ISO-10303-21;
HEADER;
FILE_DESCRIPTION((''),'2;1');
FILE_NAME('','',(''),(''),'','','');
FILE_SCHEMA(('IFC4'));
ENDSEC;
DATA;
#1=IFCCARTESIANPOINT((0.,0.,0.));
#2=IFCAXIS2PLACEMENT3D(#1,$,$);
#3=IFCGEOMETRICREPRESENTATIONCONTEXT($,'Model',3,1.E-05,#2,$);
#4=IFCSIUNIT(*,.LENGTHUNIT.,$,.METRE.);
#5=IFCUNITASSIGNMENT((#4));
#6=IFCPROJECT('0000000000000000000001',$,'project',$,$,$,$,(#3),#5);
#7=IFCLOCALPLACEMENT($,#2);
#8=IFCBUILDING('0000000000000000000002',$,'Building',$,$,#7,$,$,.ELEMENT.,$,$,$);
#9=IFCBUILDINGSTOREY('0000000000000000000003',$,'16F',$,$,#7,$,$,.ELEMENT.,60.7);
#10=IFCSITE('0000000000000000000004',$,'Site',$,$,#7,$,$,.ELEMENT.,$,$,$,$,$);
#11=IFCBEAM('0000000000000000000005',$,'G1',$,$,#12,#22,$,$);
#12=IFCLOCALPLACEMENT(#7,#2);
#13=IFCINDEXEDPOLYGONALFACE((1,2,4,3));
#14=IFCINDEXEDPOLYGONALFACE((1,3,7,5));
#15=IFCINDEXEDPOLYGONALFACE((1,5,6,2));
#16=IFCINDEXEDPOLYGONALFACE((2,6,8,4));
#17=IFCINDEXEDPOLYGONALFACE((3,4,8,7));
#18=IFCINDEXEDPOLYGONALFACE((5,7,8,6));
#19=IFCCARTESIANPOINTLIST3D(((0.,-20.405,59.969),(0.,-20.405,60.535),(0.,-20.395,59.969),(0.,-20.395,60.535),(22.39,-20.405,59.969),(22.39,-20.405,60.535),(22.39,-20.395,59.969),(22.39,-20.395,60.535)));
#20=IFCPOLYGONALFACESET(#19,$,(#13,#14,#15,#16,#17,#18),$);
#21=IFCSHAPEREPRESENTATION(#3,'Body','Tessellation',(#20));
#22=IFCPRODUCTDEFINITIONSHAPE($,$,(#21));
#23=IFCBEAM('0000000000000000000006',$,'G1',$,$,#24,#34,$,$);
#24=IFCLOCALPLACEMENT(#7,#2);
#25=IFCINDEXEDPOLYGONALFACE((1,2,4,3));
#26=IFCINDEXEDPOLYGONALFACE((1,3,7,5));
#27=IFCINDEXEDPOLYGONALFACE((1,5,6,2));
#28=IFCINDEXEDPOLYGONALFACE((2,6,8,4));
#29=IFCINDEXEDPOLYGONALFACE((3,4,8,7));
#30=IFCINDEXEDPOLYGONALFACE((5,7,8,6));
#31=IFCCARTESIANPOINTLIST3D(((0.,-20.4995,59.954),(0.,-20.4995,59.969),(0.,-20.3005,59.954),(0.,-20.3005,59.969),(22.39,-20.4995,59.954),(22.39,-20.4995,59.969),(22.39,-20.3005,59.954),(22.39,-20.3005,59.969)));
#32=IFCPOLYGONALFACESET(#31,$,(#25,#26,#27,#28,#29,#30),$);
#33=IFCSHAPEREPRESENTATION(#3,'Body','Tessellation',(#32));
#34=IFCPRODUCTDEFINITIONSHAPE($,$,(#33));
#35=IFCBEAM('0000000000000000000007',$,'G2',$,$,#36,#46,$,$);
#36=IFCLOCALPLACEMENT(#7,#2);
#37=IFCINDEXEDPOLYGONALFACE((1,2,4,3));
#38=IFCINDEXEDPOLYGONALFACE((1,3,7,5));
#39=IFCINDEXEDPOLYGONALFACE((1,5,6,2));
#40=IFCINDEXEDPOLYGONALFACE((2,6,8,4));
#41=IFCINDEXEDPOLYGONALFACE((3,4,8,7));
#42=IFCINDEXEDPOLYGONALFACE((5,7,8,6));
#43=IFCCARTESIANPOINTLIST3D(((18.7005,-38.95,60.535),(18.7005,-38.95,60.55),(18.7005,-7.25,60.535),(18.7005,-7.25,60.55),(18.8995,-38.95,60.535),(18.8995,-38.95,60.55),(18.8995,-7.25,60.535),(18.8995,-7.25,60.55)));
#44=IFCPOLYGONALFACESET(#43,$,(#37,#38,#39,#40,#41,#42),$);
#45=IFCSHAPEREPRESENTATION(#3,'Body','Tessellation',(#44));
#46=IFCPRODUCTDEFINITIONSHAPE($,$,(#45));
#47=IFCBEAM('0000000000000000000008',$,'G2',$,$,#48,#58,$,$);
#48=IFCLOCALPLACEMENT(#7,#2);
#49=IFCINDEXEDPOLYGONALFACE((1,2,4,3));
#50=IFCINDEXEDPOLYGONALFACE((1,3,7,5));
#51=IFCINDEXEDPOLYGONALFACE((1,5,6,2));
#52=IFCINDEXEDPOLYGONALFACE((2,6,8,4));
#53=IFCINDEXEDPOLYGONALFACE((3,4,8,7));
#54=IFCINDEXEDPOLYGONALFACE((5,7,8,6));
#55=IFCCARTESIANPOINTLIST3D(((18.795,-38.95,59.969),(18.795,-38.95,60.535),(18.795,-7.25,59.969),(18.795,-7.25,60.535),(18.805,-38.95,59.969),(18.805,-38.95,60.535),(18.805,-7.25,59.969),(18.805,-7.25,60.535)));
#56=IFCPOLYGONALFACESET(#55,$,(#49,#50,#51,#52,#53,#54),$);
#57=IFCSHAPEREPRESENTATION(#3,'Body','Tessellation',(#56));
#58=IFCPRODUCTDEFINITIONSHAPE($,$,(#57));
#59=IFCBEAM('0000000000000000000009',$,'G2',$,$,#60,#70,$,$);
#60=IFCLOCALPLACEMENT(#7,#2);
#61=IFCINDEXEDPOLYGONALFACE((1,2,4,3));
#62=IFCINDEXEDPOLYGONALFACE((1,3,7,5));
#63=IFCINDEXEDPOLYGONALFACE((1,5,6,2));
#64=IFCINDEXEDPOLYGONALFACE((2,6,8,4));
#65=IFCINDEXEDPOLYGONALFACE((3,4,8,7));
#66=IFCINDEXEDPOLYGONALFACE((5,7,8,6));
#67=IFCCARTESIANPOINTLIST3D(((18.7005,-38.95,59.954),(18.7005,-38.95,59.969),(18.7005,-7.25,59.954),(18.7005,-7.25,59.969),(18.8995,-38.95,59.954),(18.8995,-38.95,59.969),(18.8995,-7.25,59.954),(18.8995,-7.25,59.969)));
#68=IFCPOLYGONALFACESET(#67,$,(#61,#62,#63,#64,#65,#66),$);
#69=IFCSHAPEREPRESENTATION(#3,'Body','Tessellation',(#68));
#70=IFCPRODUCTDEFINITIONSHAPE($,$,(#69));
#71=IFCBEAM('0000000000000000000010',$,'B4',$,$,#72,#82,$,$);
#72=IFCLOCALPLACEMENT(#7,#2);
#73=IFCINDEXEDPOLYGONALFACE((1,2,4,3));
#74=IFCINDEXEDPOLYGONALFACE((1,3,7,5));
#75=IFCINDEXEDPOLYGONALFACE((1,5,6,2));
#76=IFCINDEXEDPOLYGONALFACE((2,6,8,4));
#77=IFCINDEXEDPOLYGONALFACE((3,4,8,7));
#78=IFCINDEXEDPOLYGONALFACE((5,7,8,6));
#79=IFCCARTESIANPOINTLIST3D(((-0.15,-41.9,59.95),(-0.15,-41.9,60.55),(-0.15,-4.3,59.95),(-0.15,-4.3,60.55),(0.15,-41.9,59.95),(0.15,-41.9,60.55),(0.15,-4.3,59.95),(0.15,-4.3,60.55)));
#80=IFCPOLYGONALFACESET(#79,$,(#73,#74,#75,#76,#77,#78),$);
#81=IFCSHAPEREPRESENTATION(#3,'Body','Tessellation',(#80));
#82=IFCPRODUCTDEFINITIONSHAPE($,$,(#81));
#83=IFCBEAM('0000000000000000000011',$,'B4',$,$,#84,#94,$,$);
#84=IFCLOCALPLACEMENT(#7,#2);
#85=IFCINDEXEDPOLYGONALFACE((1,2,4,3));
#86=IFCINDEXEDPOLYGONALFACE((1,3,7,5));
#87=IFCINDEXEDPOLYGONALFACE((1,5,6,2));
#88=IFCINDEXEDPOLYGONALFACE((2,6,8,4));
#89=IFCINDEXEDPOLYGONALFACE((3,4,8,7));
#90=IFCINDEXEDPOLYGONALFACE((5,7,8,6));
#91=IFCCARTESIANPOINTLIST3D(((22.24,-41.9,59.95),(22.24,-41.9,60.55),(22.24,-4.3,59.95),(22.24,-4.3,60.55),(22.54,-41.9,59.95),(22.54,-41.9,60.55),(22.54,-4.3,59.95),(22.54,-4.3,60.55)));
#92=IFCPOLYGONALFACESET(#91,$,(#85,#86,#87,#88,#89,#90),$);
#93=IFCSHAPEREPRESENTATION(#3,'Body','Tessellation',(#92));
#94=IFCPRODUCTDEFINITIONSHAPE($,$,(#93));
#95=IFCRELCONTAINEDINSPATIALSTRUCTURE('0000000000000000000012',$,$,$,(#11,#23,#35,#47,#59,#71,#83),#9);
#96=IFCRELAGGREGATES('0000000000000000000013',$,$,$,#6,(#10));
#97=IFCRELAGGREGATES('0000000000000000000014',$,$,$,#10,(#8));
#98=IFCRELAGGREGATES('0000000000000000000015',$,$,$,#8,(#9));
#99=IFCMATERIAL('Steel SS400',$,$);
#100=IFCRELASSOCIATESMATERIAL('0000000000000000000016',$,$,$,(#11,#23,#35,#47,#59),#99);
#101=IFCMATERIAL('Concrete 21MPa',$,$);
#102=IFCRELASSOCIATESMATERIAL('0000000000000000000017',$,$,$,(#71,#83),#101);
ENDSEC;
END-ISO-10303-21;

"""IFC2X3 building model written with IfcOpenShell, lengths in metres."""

from ifc_helpers import new_model, si_unit, frame, origin, origin_2d, place, context, project, spatial, rectangle, extrude, material, element, save


model = new_model("IFC2X3")

# Units and contexts
model_context = context("Model", 3, precision=1e-05, world=origin())
ifc_project = project(units=[si_unit("LENGTHUNIT", "METRE")], contexts=[model_context])

# Site, building, storey
placement = place(None, origin())
site = spatial("IfcSite", under=ifc_project, at=placement, Name="Site", CompositionType="ELEMENT")
building = spatial("IfcBuilding", under=site, at=placement, Name="Building", CompositionType="ELEMENT")
storey = spatial("IfcBuildingStorey", under=building, at=placement, Name="16F", CompositionType="ELEMENT", Elevation=60.7)

# Shared definitions
ifc_material_1 = material(Name="Concrete 21MPa")
ifc_material_2 = material(Name="Steel SS400")

# Beams
beam_1_placement = place(None, frame((11.195, -20.4, 59.969)))
element("IfcBeam", 1, at=beam_1_placement, inside=storey, material=ifc_material_2, Name="G1", context=model_context, shape_type="SweptSolid", body=[
    extrude(rectangle(XDim=22.39, YDim=0.01, at=origin_2d()), origin(), (0.0, 0.0, 1.0), 0.566),
])
beam_2_placement = place(None, frame((11.195, -20.4, 59.954)))
element("IfcBeam", 2, at=beam_2_placement, inside=storey, material=ifc_material_2, Name="G1", context=model_context, shape_type="SweptSolid", body=[
    extrude(rectangle(XDim=22.39, YDim=0.199, at=origin_2d()), origin(), (0.0, 0.0, 1.0), 0.015),
])
beam_3_placement = place(None, frame((18.8, -23.1, 60.535)))
element("IfcBeam", 3, at=beam_3_placement, inside=storey, material=ifc_material_2, Name="G2", context=model_context, shape_type="SweptSolid", body=[
    extrude(rectangle(XDim=0.199, YDim=31.7, at=origin_2d()), origin(), (0.0, 0.0, 1.0), 0.015),
])
beam_4_placement = place(None, frame((18.8, -23.1, 59.969)))
element("IfcBeam", 4, at=beam_4_placement, inside=storey, material=ifc_material_2, Name="G2", context=model_context, shape_type="SweptSolid", body=[
    extrude(rectangle(XDim=0.01, YDim=31.7, at=origin_2d()), origin(), (0.0, 0.0, 1.0), 0.566),
])
beam_5_placement = place(None, frame((18.8, -23.1, 59.954)))
element("IfcBeam", 5, at=beam_5_placement, inside=storey, material=ifc_material_2, Name="G2", context=model_context, shape_type="SweptSolid", body=[
    extrude(rectangle(XDim=0.199, YDim=31.7, at=origin_2d()), origin(), (0.0, 0.0, 1.0), 0.015),
])
for number, where, name in (
    (6, (0.0, -23.1, 59.95), "B4"),
    (7, (22.39, -23.1, 59.95), "B4"),
):
    element("IfcBeam", number, at=place(None, frame(where)), inside=storey, material=ifc_material_1, Name=name, context=model_context, shape_type="SweptSolid", body=[
        extrude(rectangle(XDim=0.3, YDim=37.6, at=origin_2d()), origin(), (0.0, 0.0, 1.0), 0.6),
    ])

save(model, "model.ifc")
